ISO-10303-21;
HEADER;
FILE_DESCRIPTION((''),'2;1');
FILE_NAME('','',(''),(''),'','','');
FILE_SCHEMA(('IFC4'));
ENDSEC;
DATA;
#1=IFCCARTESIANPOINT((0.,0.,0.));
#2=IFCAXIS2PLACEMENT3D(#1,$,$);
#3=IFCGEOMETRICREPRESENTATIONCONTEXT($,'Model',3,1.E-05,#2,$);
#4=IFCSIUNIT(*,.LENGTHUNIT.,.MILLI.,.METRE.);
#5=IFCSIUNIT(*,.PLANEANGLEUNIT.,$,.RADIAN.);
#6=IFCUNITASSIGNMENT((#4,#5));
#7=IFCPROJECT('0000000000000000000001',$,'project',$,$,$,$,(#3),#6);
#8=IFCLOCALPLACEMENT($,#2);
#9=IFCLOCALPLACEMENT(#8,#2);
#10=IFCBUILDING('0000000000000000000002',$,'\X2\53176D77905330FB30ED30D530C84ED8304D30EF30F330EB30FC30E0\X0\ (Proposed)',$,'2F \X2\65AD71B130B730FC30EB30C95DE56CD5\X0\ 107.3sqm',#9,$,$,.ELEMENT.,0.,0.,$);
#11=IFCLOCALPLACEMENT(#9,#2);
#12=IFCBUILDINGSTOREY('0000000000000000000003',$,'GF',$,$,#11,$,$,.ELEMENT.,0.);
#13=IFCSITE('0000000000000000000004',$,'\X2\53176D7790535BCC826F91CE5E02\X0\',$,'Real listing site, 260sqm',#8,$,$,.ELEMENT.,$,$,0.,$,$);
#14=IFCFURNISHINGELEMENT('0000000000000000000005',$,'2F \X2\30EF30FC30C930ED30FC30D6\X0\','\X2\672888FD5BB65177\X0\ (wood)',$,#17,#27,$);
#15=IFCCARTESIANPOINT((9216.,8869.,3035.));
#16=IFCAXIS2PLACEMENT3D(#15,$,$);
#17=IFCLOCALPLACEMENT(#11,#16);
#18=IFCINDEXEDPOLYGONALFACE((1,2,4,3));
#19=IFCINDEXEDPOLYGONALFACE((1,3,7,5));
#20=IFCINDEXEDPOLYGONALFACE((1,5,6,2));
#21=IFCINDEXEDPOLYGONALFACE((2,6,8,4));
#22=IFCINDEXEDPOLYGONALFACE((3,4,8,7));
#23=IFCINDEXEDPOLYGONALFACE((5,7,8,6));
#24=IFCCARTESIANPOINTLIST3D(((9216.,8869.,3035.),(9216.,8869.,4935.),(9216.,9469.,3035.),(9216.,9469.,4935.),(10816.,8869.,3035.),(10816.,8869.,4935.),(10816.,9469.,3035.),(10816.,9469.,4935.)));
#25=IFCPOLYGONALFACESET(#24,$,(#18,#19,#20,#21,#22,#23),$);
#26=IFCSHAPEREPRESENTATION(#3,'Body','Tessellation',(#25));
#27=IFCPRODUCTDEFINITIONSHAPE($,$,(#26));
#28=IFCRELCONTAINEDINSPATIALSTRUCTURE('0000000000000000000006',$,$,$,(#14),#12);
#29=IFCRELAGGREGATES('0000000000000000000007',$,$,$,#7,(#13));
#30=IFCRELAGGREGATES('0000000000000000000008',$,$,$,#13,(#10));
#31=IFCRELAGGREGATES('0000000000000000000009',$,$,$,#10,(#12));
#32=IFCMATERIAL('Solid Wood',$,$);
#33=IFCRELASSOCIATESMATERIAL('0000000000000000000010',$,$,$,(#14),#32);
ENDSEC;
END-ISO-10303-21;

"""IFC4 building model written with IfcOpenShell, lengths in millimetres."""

from ifc_helpers import new_model, si_unit, frame, frame_2d, origin, place, context, project, spatial, rectangle, extrude, material, element, save


model = new_model("IFC4")

# Units and contexts
model_context = context("Model", 3, precision=1e-05, world=origin())
ifc_project = project(units=[si_unit("LENGTHUNIT", "METRE", prefix="MILLI"), si_unit("PLANEANGLEUNIT", "RADIAN")], contexts=[model_context])

# Site, building, storey
site_placement = place(None, origin())
site = spatial("IfcSite", under=ifc_project, at=site_placement, Name="北海道富良野市", ObjectType="Real listing site, 260sqm", CompositionType="ELEMENT", RefElevation=0.0)
building_placement = place(site_placement, origin())
building = spatial("IfcBuilding", under=site, at=building_placement, Name="北海道・ロフト付きワンルーム (Proposed)", ObjectType="2F 断熱シールド工法 107.3sqm", CompositionType="ELEMENT", ElevationOfRefHeight=0.0, ElevationOfTerrain=0.0)
storey_placement = place(building_placement, origin())
storey = spatial("IfcBuildingStorey", under=building, at=storey_placement, Name="GF", CompositionType="ELEMENT", Elevation=0.0)

# Shared definitions
ifc_material_1 = material(Name="Solid Wood")

# Furnishing element
furnishing_placement = place(storey_placement, frame((9216.0, 8869.0, 3035.0)))
element("IfcFurnishingElement", 1, at=furnishing_placement, inside=storey, material=ifc_material_1, Name="2F ワードローブ", Description="木製家具 (wood)", context=model_context, shape_type="SweptSolid", body=[
    extrude(rectangle(XDim=1600.0, YDim=600.0, at=frame_2d((800.0, 300.0))), frame((9216.0, 8869.0, 3035.0)), (0.0, 0.0, 1.0), 1900.0),
])

save(model, "model.ifc")
